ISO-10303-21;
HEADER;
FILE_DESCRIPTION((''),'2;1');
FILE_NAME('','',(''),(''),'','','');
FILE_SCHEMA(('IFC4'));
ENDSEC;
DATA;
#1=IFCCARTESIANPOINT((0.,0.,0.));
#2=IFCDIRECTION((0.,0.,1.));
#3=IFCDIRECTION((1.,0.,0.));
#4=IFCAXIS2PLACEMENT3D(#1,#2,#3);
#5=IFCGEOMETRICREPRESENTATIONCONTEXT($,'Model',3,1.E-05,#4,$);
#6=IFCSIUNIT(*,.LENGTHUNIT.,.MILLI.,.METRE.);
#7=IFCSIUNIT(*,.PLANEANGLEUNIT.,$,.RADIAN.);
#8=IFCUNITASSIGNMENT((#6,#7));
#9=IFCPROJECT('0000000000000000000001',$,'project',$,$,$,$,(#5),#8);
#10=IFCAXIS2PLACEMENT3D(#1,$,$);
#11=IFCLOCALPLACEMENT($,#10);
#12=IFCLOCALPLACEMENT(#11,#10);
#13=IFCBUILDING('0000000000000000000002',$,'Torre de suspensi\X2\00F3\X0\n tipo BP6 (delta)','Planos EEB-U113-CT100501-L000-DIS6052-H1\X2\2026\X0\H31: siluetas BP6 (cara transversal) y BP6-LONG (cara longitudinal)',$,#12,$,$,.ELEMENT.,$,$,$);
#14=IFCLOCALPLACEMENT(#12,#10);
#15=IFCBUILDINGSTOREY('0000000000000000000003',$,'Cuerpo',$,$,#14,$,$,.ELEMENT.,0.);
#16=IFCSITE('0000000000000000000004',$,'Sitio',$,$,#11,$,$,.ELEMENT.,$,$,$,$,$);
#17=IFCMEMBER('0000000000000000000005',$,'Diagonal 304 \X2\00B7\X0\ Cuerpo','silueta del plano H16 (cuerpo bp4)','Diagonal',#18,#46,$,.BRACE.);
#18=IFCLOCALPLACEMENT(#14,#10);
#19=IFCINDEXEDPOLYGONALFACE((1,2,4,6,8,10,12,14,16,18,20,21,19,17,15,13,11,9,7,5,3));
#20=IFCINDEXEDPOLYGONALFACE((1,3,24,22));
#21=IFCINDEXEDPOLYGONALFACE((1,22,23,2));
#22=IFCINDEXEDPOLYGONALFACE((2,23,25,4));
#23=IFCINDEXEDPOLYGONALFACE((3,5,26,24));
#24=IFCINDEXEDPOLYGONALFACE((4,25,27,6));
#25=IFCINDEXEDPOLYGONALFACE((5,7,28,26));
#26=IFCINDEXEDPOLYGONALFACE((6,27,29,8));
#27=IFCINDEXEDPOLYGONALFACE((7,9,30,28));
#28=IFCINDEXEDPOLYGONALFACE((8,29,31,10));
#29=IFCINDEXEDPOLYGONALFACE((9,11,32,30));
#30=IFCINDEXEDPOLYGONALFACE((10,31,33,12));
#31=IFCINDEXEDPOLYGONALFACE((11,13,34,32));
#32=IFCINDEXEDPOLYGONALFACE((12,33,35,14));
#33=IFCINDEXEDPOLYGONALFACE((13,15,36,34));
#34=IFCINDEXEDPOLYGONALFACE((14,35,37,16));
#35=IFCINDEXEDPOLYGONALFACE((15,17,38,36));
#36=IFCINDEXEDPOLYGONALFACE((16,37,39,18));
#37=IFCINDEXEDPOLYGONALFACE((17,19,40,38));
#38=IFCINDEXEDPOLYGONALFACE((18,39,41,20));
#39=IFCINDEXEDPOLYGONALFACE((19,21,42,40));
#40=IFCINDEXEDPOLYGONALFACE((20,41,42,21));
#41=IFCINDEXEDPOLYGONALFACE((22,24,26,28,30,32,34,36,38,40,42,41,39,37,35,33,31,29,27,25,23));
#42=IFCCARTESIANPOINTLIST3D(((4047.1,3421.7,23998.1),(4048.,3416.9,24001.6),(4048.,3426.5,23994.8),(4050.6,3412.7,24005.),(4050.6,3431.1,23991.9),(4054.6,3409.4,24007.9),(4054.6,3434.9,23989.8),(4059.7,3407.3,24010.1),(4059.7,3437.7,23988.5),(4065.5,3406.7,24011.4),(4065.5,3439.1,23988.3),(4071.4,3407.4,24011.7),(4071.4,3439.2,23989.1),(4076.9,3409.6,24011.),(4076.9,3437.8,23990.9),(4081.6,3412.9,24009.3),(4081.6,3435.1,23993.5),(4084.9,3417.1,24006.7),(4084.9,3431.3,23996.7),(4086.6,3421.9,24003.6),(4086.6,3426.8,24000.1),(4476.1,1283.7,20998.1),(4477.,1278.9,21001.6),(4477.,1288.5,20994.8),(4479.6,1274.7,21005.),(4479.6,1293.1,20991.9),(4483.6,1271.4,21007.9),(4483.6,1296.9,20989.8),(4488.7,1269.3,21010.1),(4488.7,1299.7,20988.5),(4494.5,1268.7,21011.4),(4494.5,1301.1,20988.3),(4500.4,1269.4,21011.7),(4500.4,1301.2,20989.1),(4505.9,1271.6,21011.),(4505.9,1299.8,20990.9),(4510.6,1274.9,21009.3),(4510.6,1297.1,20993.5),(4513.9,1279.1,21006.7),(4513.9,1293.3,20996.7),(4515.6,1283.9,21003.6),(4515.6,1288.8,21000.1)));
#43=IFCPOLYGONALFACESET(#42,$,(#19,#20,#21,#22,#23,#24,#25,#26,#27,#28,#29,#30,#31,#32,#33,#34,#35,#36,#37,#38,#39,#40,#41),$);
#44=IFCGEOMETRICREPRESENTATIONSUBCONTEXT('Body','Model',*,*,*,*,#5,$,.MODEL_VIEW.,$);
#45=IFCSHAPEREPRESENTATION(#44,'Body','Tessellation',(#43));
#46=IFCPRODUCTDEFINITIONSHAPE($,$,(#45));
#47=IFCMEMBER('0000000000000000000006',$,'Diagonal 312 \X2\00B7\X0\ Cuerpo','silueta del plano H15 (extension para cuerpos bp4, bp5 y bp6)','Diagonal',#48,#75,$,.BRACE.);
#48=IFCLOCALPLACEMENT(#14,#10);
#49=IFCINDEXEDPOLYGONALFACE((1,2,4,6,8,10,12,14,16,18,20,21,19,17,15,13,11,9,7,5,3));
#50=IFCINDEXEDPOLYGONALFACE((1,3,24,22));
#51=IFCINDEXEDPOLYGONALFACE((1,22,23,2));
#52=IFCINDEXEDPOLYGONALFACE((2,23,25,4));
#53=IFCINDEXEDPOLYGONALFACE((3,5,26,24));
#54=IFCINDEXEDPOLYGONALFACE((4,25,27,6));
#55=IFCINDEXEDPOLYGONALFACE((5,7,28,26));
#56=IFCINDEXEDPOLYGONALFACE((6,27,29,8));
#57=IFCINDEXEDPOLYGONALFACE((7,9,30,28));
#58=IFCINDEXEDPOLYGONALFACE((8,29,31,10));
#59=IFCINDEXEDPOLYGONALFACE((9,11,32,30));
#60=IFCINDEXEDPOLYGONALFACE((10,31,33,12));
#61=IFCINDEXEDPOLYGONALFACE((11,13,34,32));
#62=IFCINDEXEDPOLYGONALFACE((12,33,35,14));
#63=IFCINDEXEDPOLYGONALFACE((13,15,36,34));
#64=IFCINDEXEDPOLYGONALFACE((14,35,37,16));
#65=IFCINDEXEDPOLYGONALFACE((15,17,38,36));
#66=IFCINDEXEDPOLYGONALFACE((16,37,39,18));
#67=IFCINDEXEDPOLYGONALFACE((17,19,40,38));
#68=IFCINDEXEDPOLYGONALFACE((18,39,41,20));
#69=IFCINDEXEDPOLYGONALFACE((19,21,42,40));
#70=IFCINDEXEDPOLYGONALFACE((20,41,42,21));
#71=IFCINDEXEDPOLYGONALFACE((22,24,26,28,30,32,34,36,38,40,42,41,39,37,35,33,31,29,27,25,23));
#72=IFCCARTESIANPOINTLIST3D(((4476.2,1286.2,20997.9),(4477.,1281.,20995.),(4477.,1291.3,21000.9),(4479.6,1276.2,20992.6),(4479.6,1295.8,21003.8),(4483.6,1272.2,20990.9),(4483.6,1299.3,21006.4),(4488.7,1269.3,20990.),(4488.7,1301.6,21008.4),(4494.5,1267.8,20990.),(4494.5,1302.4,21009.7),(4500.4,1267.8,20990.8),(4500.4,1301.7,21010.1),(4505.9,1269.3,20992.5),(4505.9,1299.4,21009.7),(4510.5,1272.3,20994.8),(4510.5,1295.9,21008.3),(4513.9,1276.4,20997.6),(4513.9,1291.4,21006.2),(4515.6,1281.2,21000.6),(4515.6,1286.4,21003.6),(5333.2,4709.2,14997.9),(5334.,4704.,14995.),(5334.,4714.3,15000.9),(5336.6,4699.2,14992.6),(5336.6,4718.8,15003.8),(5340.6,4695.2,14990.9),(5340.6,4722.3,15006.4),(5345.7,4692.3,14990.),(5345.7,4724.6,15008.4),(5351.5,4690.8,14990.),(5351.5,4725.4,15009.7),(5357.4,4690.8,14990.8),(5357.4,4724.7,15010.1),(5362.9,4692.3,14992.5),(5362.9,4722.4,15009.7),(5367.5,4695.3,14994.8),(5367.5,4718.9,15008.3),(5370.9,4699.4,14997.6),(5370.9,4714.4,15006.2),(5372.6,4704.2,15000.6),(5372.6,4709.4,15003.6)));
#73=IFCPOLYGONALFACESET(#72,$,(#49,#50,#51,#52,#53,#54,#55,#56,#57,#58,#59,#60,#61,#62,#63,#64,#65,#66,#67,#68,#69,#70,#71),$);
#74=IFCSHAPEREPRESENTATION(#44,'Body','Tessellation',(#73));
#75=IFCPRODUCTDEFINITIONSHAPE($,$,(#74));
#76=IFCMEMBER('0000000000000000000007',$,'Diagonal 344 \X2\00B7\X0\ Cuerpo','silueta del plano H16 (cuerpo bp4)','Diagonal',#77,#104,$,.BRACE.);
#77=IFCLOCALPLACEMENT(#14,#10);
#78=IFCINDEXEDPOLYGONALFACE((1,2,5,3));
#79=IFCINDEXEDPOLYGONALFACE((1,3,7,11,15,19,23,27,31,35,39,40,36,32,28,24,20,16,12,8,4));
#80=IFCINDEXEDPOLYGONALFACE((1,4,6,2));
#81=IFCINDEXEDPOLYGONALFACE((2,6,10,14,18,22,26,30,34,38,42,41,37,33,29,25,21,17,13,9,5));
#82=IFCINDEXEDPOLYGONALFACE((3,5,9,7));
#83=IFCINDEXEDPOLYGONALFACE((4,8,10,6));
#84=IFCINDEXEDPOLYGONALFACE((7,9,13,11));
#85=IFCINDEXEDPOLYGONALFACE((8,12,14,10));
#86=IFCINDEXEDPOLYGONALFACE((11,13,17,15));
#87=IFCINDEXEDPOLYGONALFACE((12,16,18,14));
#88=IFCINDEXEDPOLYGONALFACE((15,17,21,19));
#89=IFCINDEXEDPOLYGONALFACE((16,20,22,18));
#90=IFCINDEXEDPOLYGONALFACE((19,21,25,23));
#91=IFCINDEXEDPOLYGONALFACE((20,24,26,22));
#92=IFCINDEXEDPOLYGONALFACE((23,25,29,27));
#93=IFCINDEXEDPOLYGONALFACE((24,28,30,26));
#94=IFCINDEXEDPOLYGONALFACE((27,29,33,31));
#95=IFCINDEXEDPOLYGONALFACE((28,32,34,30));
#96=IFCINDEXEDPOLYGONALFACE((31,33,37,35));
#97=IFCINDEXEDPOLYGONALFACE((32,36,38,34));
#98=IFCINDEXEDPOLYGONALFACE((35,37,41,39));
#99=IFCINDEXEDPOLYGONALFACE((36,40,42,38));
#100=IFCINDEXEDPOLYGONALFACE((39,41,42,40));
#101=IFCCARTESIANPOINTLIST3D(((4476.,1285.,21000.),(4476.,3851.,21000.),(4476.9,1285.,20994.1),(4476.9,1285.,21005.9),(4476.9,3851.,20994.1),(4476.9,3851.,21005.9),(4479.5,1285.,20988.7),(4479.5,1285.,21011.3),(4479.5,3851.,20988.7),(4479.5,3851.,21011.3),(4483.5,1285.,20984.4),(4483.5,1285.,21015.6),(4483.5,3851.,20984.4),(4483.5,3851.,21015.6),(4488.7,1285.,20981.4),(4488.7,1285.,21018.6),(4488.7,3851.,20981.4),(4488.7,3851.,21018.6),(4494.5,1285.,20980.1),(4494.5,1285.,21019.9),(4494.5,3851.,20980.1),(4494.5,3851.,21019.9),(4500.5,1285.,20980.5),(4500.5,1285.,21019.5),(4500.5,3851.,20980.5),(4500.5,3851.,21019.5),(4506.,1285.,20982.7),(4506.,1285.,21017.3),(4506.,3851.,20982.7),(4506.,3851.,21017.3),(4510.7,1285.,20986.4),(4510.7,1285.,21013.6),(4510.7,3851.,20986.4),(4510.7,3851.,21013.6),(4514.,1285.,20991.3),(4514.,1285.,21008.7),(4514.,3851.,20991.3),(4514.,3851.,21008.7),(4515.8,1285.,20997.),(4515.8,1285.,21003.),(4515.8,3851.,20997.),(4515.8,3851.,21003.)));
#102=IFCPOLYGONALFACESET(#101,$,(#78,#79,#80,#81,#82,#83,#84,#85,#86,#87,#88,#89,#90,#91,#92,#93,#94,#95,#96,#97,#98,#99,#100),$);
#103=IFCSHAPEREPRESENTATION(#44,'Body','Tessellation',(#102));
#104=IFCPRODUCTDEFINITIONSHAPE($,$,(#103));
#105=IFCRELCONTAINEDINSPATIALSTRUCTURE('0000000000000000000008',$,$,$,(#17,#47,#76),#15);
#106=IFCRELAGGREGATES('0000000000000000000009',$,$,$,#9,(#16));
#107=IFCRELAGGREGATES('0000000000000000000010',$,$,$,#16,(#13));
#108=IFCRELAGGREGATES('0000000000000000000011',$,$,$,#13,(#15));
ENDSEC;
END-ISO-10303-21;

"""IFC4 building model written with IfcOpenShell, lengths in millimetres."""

from ifc_helpers import new_model, si_unit, frame, origin, origin_with_axes, place, context, subcontext, project, spatial, circle, extrude, element, save


model = new_model("IFC4")

# Units and contexts
model_context = context("Model", 3, precision=1e-05, world=origin_with_axes())
body_context = subcontext(model_context, "Body", "Model", "MODEL_VIEW")
ifc_project = project(units=[si_unit("LENGTHUNIT", "METRE", prefix="MILLI"), si_unit("PLANEANGLEUNIT", "RADIAN")], contexts=[model_context])

# Site, building, storey
site_placement = place(None, origin())
site = spatial("IfcSite", under=ifc_project, at=site_placement, Name="Sitio", CompositionType="ELEMENT")
building_placement = place(site_placement, origin())
building = spatial("IfcBuilding", under=site, at=building_placement, Name="Torre de suspensión tipo BP6 (delta)", Description="Planos EEB-U113-CT100501-L000-DIS6052-H1…H31: siluetas BP6 (cara transversal) y BP6-LONG (cara longitudinal)", CompositionType="ELEMENT")
storey_placement = place(building_placement, origin())
storey = spatial("IfcBuildingStorey", under=building, at=storey_placement, Name="Cuerpo", CompositionType="ELEMENT", Elevation=0.0)

# Members
member_1_placement = place(storey_placement, frame((4067.0, 3423.0, 24000.0), z_axis=(0.115671, -0.576469, -0.80889), x_axis=(-0.993288, -0.067132, -0.094198)))
element("IfcMember", 1, at=member_1_placement, inside=storey, Name="Diagonal 304 · Cuerpo", Description="silueta del plano H16 (cuerpo bp4)", ObjectType="Diagonal", PredefinedType="BRACE", context=body_context, shape_type="SweptSolid", body=[
    extrude(circle(Radius=20.0), None, (0.0, 0.0, 1.0), 3708.8),
])
member_2_placement = place(storey_placement, frame((4496.0, 1285.0, 21000.0), z_axis=(0.12312, 0.491761, -0.861982), x_axis=(-0.992392, 0.06101, -0.106941)))
element("IfcMember", 2, at=member_2_placement, inside=storey, Name="Diagonal 312 · Cuerpo", Description="silueta del plano H15 (extension para cuerpos bp4, bp5 y bp6)", ObjectType="Diagonal", PredefinedType="BRACE", context=body_context, shape_type="SweptSolid", body=[
    extrude(circle(Radius=20.0), None, (0.0, 0.0, 1.0), 6960.7),
])
member_3_placement = place(storey_placement, frame((4496.0, 3851.0, 21000.0), z_axis=(0.0, -1.0, 0.0), x_axis=(-1.0, 0.0, 0.0)))
element("IfcMember", 3, at=member_3_placement, inside=storey, Name="Diagonal 344 · Cuerpo", Description="silueta del plano H16 (cuerpo bp4)", ObjectType="Diagonal", PredefinedType="BRACE", context=body_context, shape_type="SweptSolid", body=[
    extrude(circle(Radius=20.0), None, (0.0, 0.0, 1.0), 2566.0),
])

save(model, "model.ifc")
